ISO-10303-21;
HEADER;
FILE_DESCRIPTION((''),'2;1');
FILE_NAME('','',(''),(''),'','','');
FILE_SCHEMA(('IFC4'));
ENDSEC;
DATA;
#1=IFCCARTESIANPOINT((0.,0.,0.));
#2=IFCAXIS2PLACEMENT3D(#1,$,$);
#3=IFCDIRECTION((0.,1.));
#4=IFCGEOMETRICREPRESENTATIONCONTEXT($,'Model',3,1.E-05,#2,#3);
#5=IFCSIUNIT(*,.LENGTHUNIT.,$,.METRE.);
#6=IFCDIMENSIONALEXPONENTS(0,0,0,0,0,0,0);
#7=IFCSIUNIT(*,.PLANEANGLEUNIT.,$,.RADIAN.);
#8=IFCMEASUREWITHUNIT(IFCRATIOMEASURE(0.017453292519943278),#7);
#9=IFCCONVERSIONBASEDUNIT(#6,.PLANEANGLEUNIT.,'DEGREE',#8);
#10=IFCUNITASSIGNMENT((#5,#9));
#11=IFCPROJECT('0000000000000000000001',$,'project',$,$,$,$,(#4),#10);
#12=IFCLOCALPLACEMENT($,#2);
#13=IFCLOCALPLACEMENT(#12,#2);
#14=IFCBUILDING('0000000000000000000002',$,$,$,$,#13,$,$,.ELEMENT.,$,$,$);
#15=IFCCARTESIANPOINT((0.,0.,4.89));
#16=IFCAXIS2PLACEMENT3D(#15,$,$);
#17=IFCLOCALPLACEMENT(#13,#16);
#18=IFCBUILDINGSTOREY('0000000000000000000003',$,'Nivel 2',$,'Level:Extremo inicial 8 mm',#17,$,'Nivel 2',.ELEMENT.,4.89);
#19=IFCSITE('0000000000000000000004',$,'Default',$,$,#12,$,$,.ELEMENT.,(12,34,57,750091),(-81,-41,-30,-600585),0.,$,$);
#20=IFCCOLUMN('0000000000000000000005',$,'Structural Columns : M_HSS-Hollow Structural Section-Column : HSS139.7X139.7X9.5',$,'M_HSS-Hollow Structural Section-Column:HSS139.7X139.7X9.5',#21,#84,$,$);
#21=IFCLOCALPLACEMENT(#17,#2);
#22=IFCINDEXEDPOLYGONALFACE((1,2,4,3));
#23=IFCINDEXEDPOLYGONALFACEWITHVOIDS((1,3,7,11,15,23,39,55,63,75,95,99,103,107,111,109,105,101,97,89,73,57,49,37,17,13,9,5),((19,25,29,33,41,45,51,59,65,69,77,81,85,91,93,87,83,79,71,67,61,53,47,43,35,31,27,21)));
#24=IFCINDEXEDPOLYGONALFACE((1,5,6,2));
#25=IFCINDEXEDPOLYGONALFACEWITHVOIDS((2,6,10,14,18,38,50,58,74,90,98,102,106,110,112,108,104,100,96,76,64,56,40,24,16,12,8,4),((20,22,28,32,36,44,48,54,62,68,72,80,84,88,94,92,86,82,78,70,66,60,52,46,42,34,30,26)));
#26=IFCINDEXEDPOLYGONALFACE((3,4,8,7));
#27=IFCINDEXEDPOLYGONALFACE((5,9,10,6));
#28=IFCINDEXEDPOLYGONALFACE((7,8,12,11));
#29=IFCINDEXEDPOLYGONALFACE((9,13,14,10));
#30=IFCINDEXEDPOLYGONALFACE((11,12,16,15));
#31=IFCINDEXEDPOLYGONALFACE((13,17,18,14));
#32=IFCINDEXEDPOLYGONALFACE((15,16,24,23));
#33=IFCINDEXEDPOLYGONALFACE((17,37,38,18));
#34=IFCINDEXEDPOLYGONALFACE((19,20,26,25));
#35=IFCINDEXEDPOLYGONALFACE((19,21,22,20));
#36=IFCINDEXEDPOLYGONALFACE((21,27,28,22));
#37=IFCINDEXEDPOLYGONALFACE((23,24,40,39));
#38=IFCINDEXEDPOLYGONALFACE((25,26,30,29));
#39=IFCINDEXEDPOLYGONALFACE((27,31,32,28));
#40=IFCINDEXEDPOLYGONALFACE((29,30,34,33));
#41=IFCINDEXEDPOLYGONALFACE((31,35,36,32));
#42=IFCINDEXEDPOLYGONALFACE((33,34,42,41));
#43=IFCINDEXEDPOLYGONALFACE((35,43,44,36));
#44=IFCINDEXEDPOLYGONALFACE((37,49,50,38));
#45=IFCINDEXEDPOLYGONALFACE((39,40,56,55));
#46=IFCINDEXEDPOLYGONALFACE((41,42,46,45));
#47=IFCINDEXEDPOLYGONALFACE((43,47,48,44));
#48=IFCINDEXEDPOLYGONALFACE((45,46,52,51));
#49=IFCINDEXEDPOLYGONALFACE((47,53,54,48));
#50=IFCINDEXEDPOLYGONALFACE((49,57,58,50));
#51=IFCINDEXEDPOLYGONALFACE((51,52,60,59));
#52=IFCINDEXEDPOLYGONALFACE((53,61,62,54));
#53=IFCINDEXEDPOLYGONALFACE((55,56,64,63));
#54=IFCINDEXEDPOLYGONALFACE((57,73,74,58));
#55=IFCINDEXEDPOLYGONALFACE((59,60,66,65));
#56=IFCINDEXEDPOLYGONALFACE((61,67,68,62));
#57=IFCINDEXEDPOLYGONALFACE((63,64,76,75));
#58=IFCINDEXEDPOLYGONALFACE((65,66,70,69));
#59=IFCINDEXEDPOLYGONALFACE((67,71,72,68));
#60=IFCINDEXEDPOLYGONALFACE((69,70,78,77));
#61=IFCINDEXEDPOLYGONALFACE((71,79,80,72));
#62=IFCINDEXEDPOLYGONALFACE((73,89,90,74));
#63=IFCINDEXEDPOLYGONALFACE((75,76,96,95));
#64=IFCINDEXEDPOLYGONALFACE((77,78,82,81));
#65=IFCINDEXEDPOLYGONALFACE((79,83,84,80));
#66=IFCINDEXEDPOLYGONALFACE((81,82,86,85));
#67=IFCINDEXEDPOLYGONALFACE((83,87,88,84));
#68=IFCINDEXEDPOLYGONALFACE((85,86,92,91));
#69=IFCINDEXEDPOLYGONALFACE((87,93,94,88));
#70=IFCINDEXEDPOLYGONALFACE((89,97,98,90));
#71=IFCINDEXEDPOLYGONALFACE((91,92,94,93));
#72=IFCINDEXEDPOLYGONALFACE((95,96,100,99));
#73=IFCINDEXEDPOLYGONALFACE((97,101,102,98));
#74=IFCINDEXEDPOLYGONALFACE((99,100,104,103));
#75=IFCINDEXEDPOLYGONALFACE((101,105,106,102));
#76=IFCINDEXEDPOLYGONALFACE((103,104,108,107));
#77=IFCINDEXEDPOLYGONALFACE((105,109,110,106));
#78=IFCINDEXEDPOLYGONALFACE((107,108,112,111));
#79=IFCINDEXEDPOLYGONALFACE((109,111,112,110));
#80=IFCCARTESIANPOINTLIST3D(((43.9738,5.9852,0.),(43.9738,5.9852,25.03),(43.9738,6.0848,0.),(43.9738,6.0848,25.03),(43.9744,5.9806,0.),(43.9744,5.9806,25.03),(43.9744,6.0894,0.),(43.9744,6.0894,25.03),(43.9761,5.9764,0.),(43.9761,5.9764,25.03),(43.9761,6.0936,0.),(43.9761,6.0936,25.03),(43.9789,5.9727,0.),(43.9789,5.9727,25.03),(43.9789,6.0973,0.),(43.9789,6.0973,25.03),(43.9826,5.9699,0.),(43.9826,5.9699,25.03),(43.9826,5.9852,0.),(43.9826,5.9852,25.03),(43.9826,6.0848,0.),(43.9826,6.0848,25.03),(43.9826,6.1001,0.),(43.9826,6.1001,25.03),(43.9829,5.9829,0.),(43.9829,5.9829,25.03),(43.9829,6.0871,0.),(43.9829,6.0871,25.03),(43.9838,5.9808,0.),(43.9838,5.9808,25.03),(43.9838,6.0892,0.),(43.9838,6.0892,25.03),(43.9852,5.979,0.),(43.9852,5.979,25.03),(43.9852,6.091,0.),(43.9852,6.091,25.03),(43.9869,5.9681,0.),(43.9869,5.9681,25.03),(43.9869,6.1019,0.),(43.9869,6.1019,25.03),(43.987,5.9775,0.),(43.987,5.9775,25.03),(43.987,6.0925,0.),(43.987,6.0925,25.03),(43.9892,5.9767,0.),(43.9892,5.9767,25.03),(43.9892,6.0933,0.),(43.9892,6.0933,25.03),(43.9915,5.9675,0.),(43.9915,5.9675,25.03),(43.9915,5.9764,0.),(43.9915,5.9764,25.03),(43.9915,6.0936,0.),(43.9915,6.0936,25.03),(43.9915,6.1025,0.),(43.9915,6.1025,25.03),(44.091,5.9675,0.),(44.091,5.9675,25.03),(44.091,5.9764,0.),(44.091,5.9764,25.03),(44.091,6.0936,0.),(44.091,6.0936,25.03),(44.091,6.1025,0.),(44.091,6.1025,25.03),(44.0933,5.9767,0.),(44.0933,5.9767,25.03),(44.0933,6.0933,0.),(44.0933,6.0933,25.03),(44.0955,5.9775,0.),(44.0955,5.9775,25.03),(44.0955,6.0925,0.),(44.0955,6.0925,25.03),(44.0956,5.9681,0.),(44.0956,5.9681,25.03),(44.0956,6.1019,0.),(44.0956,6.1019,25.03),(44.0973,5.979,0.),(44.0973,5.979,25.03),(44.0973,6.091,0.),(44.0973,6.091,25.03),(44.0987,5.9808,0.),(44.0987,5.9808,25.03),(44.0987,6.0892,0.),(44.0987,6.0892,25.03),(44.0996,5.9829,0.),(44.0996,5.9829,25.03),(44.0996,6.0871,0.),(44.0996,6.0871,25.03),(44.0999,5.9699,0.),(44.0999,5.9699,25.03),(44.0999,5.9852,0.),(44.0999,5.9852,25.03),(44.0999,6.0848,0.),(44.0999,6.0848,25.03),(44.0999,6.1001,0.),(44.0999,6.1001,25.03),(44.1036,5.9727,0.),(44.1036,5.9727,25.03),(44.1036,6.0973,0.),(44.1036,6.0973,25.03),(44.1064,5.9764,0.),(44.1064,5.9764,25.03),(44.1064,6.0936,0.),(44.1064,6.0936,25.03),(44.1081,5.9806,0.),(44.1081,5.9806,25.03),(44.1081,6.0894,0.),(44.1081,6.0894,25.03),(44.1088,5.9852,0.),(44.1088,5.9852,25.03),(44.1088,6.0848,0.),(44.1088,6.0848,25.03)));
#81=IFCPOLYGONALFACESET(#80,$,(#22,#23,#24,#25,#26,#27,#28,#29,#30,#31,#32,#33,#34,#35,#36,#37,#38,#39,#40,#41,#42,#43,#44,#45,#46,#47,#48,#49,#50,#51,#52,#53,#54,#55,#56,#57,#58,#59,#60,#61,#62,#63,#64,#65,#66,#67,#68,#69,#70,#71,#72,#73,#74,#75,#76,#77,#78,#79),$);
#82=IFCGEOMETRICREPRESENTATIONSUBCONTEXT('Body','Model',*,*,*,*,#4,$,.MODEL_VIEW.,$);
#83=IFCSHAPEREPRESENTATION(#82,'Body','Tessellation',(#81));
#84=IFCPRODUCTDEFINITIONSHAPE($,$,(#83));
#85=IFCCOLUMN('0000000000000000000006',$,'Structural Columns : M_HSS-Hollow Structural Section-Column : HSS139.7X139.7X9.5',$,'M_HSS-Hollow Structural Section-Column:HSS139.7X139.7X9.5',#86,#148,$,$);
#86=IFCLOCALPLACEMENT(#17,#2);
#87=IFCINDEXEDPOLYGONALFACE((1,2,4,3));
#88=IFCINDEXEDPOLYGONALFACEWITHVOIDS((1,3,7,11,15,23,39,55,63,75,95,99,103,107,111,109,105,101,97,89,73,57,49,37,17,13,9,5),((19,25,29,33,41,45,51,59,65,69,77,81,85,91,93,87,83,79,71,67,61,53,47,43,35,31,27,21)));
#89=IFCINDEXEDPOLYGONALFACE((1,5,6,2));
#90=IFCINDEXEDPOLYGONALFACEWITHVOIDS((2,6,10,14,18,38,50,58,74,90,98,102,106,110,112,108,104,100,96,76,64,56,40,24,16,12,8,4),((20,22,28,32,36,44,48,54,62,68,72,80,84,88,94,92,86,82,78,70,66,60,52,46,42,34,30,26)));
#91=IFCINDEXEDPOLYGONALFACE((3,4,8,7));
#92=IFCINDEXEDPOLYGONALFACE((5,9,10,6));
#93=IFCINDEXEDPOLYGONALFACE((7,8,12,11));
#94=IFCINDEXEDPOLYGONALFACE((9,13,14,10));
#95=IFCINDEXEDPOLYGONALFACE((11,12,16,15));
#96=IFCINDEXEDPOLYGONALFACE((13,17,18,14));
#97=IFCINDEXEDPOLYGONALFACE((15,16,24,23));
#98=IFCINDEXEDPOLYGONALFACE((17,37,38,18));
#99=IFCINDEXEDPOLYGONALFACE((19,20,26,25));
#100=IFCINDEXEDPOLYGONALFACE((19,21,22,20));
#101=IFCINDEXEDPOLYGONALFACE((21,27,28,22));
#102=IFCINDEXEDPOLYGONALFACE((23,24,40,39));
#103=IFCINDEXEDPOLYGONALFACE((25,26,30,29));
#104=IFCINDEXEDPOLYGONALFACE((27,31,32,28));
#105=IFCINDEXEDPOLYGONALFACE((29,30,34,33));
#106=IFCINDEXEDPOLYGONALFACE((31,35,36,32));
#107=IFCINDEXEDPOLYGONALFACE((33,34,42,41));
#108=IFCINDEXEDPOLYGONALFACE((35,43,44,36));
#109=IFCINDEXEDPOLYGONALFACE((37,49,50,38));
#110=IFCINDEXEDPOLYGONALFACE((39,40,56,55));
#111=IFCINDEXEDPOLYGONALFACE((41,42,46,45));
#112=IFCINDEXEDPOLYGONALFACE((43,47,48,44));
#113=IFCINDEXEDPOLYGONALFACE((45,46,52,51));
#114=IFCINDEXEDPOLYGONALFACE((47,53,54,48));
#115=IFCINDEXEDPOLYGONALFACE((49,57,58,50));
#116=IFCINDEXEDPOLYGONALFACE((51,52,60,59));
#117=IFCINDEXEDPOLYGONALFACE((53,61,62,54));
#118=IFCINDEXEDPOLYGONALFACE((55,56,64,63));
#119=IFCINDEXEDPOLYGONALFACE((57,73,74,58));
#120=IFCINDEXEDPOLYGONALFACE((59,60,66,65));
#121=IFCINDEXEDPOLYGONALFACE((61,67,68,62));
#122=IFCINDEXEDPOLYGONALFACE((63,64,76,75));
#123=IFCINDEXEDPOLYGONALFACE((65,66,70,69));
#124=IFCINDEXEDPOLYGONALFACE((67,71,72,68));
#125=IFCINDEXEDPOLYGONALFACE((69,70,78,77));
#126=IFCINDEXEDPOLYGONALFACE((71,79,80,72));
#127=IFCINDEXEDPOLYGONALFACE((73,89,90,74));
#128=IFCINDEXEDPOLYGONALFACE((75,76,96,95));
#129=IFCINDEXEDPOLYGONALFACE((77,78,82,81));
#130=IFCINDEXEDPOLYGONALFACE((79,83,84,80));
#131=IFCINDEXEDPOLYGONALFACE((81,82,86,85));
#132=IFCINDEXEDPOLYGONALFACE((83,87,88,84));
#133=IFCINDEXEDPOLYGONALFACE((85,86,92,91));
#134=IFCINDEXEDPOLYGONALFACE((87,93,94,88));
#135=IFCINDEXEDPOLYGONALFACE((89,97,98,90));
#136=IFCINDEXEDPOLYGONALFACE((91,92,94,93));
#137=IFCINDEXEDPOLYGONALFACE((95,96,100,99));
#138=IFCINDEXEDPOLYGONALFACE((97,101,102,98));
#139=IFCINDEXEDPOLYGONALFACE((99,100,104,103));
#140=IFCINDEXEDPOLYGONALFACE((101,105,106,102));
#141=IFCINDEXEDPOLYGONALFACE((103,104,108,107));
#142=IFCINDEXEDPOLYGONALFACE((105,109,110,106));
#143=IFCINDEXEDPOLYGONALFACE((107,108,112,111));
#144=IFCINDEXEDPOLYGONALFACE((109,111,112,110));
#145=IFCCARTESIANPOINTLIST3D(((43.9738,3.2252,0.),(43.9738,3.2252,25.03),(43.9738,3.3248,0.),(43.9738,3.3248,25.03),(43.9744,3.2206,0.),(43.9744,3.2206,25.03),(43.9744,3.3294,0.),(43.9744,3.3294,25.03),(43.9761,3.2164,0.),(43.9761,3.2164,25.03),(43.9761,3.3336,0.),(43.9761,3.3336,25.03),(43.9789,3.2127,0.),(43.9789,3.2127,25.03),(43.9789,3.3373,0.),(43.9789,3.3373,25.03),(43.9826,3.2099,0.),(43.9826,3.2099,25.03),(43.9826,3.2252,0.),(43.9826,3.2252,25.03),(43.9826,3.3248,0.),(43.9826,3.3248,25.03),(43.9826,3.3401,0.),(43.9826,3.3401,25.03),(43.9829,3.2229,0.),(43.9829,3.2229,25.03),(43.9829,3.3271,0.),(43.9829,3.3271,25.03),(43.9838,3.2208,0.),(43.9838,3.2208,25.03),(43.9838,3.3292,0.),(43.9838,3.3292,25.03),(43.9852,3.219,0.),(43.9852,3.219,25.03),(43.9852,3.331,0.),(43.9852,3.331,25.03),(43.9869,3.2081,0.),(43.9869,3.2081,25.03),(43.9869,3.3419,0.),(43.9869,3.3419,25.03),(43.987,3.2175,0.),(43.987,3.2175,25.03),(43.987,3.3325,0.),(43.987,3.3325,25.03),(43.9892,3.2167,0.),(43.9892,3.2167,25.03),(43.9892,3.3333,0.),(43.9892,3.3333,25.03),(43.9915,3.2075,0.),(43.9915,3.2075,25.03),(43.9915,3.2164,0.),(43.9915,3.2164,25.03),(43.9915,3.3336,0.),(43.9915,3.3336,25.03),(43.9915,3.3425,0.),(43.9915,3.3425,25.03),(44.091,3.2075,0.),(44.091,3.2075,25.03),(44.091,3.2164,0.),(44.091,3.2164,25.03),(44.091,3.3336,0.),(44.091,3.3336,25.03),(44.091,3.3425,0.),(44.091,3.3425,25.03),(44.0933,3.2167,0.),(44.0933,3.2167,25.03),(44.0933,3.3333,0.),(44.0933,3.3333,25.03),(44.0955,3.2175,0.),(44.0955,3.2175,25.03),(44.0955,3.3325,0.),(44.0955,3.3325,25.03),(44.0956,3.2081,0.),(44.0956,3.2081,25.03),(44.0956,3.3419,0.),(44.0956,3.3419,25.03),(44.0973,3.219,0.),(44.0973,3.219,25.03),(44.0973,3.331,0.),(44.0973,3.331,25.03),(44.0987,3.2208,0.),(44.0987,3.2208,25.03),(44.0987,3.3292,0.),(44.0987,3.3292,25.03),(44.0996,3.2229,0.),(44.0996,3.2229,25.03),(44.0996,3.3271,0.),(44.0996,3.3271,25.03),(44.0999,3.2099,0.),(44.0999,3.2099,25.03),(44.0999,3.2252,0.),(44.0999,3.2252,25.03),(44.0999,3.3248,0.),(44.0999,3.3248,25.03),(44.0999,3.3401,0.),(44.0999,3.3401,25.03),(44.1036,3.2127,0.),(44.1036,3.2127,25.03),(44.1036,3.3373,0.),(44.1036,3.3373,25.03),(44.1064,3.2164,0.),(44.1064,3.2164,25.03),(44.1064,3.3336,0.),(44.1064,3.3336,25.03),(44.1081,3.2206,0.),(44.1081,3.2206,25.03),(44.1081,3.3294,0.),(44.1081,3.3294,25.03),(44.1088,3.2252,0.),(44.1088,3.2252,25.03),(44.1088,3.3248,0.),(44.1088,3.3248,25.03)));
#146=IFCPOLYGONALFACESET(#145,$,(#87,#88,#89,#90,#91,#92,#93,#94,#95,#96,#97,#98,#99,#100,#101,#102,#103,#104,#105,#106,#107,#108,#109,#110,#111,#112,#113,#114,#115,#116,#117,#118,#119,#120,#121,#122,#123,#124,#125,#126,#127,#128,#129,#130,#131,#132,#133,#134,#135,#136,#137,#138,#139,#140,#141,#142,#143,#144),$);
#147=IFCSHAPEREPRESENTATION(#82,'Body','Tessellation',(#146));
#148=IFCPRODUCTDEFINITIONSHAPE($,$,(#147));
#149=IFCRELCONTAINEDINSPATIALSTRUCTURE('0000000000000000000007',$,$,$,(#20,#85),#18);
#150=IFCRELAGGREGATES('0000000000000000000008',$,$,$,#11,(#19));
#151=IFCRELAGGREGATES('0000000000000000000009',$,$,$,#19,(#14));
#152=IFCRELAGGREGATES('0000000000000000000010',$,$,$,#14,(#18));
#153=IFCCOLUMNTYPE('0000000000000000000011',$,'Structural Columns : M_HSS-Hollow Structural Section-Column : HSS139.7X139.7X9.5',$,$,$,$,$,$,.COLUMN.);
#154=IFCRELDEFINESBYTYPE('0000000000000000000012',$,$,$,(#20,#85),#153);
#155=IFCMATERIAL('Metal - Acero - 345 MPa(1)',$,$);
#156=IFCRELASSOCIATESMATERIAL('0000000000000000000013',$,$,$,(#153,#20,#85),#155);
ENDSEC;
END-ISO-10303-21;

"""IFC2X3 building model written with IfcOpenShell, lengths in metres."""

from ifc_helpers import new_model, entity, si_unit, converted_unit, direction, frame, frame_2d, origin, place, context, subcontext, project, spatial, polyline, circle_curve, parameter, trimmed, segment, composite_curve, outline, extrude, source, transform, mapped, material, type_object, type_shapes, element, save


model = new_model("IFC2X3")

# Units and contexts
model_context = context("Model", 3, precision=1e-05, world=origin(), true_north=direction((0.0, 1.0)))
body_context = subcontext(model_context, "Body", "Model", "MODEL_VIEW")
ifc_project = project(units=[si_unit("LENGTHUNIT", "METRE"), converted_unit("PLANEANGLEUNIT", "DEGREE", entity("IfcRatioMeasure", 0.017453292519943278), si_unit("PLANEANGLEUNIT", "RADIAN"), dimensions=[0, 0, 0, 0, 0, 0, 0])], contexts=[model_context])

# Site, building, storey
site_placement = place(None, origin())
site = spatial("IfcSite", under=ifc_project, at=site_placement, Name="Default", CompositionType="ELEMENT", RefLatitude=(12, 34, 57, 750091), RefLongitude=(-81, -41, -30, -600585), RefElevation=0.0)
building_placement = place(site_placement, origin())
building = spatial("IfcBuilding", under=site, at=building_placement, CompositionType="ELEMENT")
storey_placement = place(building_placement, frame((0.0, 0.0, 4.89)))
storey = spatial("IfcBuildingStorey", under=building, at=storey_placement, Name="Nivel 2", ObjectType="Level:Extremo inicial 8 mm", LongName="Nivel 2", CompositionType="ELEMENT", Elevation=4.89)

# Columns
ifc_material_1 = material(Name="Metal - Acero - 345 MPa(1)")
column_type_1 = type_object("IfcColumnType", Name="Structural Columns : M_HSS-Hollow Structural Section-Column : HSS139.7X139.7X9.5", PredefinedType="COLUMN", material=ifc_material_1)
shared_shape_1 = source(origin(), body_context, "Body", "SweptSolid", [
    extrude(outline(composite_curve([segment(polyline([(-0.0498, -0.0675), (0.0498, -0.0675)]), True, "CONTINUOUS"), segment(trimmed(circle_curve(frame_2d((0.0498, -0.0498), x_axis=(-1.0, 0.0)), 0.0177), [parameter(90.0)], [parameter(180.0)], True, "PARAMETER"), True, "CONTINUOUS"), segment(polyline([(0.0675, -0.0498), (0.0675, 0.0498)]), True, "CONTINUOUS"), segment(trimmed(circle_curve(frame_2d((0.0498, 0.0498), x_axis=(-1.0, 0.0)), 0.0177), [parameter(180.0)], [parameter(270.0)], True, "PARAMETER"), True, "CONTINUOUS"), segment(polyline([(0.0498, 0.0675), (-0.0498, 0.0675)]), True, "CONTINUOUS"), segment(trimmed(circle_curve(frame_2d((-0.0498, 0.0498), x_axis=(-1.0, 0.0)), 0.0177), [parameter(270.0)], [parameter(360.0)], True, "PARAMETER"), True, "CONTINUOUS"), segment(polyline([(-0.0675, 0.0498), (-0.0675, -0.0498)]), True, "CONTINUOUS"), segment(trimmed(circle_curve(frame_2d((-0.0498, -0.0498), x_axis=(-1.0, 0.0)), 0.0177), [parameter(360.0)], [parameter(90.0)], True, "PARAMETER"), True, "CONTINUOUS")], self_intersect=False), holes=[composite_curve([segment(trimmed(circle_curve(frame_2d((-0.0498, -0.0498), x_axis=(-1.0, 0.0)), 0.0089), [parameter(0.0)], [parameter(90.0)], True, "PARAMETER"), False, "CONTINUOUS"), segment(polyline([(-0.0586, -0.0498), (-0.0586, 0.0498)]), True, "CONTINUOUS"), segment(trimmed(circle_curve(frame_2d((-0.0498, 0.0498), x_axis=(-1.0, 0.0)), 0.0089), [parameter(270.0)], [parameter(0.0)], True, "PARAMETER"), False, "CONTINUOUS"), segment(polyline([(-0.0498, 0.0586), (0.0498, 0.0586)]), True, "CONTINUOUS"), segment(trimmed(circle_curve(frame_2d((0.0498, 0.0498), x_axis=(-1.0, 0.0)), 0.0089), [parameter(180.0)], [parameter(270.0)], True, "PARAMETER"), False, "CONTINUOUS"), segment(polyline([(0.0586, 0.0498), (0.0586, -0.0498)]), True, "CONTINUOUS"), segment(trimmed(circle_curve(frame_2d((0.0498, -0.0498), x_axis=(-1.0, 0.0)), 0.0089), [parameter(90.0)], [parameter(180.0)], True, "PARAMETER"), False, "CONTINUOUS"), segment(polyline([(0.0498, -0.0586), (-0.0498, -0.0586)]), True, "CONTINUOUS")], self_intersect=False)]), frame((0.0, 0.0, 4.89), z_axis=(0.0, 0.0, 1.0), x_axis=(-1.0, 0.0, 0.0)), (0.0, 0.0, 1.0), 25.03),
])
type_shapes(column_type_1, [shared_shape_1])
for number, where, name in (
    (1, (44.0413, 6.035, -4.89), "Structural Columns : M_HSS-Hollow Structural Section-Column : HSS139.7X139.7X9.5"),
    (2, (44.0413, 3.275, -4.89), "Structural Columns : M_HSS-Hollow Structural Section-Column : HSS139.7X139.7X9.5"),
):
    element("IfcColumn", number, at=place(storey_placement, frame(where)), inside=storey, type_object=column_type_1, material=ifc_material_1, Name=name, ObjectType="M_HSS-Hollow Structural Section-Column:HSS139.7X139.7X9.5", context=body_context, shape_type="MappedRepresentation", body=[
        mapped(shared_shape_1, transform((0.0, 0.0, 0.0), scale=1.0)),
    ])

save(model, "model.ifc")
